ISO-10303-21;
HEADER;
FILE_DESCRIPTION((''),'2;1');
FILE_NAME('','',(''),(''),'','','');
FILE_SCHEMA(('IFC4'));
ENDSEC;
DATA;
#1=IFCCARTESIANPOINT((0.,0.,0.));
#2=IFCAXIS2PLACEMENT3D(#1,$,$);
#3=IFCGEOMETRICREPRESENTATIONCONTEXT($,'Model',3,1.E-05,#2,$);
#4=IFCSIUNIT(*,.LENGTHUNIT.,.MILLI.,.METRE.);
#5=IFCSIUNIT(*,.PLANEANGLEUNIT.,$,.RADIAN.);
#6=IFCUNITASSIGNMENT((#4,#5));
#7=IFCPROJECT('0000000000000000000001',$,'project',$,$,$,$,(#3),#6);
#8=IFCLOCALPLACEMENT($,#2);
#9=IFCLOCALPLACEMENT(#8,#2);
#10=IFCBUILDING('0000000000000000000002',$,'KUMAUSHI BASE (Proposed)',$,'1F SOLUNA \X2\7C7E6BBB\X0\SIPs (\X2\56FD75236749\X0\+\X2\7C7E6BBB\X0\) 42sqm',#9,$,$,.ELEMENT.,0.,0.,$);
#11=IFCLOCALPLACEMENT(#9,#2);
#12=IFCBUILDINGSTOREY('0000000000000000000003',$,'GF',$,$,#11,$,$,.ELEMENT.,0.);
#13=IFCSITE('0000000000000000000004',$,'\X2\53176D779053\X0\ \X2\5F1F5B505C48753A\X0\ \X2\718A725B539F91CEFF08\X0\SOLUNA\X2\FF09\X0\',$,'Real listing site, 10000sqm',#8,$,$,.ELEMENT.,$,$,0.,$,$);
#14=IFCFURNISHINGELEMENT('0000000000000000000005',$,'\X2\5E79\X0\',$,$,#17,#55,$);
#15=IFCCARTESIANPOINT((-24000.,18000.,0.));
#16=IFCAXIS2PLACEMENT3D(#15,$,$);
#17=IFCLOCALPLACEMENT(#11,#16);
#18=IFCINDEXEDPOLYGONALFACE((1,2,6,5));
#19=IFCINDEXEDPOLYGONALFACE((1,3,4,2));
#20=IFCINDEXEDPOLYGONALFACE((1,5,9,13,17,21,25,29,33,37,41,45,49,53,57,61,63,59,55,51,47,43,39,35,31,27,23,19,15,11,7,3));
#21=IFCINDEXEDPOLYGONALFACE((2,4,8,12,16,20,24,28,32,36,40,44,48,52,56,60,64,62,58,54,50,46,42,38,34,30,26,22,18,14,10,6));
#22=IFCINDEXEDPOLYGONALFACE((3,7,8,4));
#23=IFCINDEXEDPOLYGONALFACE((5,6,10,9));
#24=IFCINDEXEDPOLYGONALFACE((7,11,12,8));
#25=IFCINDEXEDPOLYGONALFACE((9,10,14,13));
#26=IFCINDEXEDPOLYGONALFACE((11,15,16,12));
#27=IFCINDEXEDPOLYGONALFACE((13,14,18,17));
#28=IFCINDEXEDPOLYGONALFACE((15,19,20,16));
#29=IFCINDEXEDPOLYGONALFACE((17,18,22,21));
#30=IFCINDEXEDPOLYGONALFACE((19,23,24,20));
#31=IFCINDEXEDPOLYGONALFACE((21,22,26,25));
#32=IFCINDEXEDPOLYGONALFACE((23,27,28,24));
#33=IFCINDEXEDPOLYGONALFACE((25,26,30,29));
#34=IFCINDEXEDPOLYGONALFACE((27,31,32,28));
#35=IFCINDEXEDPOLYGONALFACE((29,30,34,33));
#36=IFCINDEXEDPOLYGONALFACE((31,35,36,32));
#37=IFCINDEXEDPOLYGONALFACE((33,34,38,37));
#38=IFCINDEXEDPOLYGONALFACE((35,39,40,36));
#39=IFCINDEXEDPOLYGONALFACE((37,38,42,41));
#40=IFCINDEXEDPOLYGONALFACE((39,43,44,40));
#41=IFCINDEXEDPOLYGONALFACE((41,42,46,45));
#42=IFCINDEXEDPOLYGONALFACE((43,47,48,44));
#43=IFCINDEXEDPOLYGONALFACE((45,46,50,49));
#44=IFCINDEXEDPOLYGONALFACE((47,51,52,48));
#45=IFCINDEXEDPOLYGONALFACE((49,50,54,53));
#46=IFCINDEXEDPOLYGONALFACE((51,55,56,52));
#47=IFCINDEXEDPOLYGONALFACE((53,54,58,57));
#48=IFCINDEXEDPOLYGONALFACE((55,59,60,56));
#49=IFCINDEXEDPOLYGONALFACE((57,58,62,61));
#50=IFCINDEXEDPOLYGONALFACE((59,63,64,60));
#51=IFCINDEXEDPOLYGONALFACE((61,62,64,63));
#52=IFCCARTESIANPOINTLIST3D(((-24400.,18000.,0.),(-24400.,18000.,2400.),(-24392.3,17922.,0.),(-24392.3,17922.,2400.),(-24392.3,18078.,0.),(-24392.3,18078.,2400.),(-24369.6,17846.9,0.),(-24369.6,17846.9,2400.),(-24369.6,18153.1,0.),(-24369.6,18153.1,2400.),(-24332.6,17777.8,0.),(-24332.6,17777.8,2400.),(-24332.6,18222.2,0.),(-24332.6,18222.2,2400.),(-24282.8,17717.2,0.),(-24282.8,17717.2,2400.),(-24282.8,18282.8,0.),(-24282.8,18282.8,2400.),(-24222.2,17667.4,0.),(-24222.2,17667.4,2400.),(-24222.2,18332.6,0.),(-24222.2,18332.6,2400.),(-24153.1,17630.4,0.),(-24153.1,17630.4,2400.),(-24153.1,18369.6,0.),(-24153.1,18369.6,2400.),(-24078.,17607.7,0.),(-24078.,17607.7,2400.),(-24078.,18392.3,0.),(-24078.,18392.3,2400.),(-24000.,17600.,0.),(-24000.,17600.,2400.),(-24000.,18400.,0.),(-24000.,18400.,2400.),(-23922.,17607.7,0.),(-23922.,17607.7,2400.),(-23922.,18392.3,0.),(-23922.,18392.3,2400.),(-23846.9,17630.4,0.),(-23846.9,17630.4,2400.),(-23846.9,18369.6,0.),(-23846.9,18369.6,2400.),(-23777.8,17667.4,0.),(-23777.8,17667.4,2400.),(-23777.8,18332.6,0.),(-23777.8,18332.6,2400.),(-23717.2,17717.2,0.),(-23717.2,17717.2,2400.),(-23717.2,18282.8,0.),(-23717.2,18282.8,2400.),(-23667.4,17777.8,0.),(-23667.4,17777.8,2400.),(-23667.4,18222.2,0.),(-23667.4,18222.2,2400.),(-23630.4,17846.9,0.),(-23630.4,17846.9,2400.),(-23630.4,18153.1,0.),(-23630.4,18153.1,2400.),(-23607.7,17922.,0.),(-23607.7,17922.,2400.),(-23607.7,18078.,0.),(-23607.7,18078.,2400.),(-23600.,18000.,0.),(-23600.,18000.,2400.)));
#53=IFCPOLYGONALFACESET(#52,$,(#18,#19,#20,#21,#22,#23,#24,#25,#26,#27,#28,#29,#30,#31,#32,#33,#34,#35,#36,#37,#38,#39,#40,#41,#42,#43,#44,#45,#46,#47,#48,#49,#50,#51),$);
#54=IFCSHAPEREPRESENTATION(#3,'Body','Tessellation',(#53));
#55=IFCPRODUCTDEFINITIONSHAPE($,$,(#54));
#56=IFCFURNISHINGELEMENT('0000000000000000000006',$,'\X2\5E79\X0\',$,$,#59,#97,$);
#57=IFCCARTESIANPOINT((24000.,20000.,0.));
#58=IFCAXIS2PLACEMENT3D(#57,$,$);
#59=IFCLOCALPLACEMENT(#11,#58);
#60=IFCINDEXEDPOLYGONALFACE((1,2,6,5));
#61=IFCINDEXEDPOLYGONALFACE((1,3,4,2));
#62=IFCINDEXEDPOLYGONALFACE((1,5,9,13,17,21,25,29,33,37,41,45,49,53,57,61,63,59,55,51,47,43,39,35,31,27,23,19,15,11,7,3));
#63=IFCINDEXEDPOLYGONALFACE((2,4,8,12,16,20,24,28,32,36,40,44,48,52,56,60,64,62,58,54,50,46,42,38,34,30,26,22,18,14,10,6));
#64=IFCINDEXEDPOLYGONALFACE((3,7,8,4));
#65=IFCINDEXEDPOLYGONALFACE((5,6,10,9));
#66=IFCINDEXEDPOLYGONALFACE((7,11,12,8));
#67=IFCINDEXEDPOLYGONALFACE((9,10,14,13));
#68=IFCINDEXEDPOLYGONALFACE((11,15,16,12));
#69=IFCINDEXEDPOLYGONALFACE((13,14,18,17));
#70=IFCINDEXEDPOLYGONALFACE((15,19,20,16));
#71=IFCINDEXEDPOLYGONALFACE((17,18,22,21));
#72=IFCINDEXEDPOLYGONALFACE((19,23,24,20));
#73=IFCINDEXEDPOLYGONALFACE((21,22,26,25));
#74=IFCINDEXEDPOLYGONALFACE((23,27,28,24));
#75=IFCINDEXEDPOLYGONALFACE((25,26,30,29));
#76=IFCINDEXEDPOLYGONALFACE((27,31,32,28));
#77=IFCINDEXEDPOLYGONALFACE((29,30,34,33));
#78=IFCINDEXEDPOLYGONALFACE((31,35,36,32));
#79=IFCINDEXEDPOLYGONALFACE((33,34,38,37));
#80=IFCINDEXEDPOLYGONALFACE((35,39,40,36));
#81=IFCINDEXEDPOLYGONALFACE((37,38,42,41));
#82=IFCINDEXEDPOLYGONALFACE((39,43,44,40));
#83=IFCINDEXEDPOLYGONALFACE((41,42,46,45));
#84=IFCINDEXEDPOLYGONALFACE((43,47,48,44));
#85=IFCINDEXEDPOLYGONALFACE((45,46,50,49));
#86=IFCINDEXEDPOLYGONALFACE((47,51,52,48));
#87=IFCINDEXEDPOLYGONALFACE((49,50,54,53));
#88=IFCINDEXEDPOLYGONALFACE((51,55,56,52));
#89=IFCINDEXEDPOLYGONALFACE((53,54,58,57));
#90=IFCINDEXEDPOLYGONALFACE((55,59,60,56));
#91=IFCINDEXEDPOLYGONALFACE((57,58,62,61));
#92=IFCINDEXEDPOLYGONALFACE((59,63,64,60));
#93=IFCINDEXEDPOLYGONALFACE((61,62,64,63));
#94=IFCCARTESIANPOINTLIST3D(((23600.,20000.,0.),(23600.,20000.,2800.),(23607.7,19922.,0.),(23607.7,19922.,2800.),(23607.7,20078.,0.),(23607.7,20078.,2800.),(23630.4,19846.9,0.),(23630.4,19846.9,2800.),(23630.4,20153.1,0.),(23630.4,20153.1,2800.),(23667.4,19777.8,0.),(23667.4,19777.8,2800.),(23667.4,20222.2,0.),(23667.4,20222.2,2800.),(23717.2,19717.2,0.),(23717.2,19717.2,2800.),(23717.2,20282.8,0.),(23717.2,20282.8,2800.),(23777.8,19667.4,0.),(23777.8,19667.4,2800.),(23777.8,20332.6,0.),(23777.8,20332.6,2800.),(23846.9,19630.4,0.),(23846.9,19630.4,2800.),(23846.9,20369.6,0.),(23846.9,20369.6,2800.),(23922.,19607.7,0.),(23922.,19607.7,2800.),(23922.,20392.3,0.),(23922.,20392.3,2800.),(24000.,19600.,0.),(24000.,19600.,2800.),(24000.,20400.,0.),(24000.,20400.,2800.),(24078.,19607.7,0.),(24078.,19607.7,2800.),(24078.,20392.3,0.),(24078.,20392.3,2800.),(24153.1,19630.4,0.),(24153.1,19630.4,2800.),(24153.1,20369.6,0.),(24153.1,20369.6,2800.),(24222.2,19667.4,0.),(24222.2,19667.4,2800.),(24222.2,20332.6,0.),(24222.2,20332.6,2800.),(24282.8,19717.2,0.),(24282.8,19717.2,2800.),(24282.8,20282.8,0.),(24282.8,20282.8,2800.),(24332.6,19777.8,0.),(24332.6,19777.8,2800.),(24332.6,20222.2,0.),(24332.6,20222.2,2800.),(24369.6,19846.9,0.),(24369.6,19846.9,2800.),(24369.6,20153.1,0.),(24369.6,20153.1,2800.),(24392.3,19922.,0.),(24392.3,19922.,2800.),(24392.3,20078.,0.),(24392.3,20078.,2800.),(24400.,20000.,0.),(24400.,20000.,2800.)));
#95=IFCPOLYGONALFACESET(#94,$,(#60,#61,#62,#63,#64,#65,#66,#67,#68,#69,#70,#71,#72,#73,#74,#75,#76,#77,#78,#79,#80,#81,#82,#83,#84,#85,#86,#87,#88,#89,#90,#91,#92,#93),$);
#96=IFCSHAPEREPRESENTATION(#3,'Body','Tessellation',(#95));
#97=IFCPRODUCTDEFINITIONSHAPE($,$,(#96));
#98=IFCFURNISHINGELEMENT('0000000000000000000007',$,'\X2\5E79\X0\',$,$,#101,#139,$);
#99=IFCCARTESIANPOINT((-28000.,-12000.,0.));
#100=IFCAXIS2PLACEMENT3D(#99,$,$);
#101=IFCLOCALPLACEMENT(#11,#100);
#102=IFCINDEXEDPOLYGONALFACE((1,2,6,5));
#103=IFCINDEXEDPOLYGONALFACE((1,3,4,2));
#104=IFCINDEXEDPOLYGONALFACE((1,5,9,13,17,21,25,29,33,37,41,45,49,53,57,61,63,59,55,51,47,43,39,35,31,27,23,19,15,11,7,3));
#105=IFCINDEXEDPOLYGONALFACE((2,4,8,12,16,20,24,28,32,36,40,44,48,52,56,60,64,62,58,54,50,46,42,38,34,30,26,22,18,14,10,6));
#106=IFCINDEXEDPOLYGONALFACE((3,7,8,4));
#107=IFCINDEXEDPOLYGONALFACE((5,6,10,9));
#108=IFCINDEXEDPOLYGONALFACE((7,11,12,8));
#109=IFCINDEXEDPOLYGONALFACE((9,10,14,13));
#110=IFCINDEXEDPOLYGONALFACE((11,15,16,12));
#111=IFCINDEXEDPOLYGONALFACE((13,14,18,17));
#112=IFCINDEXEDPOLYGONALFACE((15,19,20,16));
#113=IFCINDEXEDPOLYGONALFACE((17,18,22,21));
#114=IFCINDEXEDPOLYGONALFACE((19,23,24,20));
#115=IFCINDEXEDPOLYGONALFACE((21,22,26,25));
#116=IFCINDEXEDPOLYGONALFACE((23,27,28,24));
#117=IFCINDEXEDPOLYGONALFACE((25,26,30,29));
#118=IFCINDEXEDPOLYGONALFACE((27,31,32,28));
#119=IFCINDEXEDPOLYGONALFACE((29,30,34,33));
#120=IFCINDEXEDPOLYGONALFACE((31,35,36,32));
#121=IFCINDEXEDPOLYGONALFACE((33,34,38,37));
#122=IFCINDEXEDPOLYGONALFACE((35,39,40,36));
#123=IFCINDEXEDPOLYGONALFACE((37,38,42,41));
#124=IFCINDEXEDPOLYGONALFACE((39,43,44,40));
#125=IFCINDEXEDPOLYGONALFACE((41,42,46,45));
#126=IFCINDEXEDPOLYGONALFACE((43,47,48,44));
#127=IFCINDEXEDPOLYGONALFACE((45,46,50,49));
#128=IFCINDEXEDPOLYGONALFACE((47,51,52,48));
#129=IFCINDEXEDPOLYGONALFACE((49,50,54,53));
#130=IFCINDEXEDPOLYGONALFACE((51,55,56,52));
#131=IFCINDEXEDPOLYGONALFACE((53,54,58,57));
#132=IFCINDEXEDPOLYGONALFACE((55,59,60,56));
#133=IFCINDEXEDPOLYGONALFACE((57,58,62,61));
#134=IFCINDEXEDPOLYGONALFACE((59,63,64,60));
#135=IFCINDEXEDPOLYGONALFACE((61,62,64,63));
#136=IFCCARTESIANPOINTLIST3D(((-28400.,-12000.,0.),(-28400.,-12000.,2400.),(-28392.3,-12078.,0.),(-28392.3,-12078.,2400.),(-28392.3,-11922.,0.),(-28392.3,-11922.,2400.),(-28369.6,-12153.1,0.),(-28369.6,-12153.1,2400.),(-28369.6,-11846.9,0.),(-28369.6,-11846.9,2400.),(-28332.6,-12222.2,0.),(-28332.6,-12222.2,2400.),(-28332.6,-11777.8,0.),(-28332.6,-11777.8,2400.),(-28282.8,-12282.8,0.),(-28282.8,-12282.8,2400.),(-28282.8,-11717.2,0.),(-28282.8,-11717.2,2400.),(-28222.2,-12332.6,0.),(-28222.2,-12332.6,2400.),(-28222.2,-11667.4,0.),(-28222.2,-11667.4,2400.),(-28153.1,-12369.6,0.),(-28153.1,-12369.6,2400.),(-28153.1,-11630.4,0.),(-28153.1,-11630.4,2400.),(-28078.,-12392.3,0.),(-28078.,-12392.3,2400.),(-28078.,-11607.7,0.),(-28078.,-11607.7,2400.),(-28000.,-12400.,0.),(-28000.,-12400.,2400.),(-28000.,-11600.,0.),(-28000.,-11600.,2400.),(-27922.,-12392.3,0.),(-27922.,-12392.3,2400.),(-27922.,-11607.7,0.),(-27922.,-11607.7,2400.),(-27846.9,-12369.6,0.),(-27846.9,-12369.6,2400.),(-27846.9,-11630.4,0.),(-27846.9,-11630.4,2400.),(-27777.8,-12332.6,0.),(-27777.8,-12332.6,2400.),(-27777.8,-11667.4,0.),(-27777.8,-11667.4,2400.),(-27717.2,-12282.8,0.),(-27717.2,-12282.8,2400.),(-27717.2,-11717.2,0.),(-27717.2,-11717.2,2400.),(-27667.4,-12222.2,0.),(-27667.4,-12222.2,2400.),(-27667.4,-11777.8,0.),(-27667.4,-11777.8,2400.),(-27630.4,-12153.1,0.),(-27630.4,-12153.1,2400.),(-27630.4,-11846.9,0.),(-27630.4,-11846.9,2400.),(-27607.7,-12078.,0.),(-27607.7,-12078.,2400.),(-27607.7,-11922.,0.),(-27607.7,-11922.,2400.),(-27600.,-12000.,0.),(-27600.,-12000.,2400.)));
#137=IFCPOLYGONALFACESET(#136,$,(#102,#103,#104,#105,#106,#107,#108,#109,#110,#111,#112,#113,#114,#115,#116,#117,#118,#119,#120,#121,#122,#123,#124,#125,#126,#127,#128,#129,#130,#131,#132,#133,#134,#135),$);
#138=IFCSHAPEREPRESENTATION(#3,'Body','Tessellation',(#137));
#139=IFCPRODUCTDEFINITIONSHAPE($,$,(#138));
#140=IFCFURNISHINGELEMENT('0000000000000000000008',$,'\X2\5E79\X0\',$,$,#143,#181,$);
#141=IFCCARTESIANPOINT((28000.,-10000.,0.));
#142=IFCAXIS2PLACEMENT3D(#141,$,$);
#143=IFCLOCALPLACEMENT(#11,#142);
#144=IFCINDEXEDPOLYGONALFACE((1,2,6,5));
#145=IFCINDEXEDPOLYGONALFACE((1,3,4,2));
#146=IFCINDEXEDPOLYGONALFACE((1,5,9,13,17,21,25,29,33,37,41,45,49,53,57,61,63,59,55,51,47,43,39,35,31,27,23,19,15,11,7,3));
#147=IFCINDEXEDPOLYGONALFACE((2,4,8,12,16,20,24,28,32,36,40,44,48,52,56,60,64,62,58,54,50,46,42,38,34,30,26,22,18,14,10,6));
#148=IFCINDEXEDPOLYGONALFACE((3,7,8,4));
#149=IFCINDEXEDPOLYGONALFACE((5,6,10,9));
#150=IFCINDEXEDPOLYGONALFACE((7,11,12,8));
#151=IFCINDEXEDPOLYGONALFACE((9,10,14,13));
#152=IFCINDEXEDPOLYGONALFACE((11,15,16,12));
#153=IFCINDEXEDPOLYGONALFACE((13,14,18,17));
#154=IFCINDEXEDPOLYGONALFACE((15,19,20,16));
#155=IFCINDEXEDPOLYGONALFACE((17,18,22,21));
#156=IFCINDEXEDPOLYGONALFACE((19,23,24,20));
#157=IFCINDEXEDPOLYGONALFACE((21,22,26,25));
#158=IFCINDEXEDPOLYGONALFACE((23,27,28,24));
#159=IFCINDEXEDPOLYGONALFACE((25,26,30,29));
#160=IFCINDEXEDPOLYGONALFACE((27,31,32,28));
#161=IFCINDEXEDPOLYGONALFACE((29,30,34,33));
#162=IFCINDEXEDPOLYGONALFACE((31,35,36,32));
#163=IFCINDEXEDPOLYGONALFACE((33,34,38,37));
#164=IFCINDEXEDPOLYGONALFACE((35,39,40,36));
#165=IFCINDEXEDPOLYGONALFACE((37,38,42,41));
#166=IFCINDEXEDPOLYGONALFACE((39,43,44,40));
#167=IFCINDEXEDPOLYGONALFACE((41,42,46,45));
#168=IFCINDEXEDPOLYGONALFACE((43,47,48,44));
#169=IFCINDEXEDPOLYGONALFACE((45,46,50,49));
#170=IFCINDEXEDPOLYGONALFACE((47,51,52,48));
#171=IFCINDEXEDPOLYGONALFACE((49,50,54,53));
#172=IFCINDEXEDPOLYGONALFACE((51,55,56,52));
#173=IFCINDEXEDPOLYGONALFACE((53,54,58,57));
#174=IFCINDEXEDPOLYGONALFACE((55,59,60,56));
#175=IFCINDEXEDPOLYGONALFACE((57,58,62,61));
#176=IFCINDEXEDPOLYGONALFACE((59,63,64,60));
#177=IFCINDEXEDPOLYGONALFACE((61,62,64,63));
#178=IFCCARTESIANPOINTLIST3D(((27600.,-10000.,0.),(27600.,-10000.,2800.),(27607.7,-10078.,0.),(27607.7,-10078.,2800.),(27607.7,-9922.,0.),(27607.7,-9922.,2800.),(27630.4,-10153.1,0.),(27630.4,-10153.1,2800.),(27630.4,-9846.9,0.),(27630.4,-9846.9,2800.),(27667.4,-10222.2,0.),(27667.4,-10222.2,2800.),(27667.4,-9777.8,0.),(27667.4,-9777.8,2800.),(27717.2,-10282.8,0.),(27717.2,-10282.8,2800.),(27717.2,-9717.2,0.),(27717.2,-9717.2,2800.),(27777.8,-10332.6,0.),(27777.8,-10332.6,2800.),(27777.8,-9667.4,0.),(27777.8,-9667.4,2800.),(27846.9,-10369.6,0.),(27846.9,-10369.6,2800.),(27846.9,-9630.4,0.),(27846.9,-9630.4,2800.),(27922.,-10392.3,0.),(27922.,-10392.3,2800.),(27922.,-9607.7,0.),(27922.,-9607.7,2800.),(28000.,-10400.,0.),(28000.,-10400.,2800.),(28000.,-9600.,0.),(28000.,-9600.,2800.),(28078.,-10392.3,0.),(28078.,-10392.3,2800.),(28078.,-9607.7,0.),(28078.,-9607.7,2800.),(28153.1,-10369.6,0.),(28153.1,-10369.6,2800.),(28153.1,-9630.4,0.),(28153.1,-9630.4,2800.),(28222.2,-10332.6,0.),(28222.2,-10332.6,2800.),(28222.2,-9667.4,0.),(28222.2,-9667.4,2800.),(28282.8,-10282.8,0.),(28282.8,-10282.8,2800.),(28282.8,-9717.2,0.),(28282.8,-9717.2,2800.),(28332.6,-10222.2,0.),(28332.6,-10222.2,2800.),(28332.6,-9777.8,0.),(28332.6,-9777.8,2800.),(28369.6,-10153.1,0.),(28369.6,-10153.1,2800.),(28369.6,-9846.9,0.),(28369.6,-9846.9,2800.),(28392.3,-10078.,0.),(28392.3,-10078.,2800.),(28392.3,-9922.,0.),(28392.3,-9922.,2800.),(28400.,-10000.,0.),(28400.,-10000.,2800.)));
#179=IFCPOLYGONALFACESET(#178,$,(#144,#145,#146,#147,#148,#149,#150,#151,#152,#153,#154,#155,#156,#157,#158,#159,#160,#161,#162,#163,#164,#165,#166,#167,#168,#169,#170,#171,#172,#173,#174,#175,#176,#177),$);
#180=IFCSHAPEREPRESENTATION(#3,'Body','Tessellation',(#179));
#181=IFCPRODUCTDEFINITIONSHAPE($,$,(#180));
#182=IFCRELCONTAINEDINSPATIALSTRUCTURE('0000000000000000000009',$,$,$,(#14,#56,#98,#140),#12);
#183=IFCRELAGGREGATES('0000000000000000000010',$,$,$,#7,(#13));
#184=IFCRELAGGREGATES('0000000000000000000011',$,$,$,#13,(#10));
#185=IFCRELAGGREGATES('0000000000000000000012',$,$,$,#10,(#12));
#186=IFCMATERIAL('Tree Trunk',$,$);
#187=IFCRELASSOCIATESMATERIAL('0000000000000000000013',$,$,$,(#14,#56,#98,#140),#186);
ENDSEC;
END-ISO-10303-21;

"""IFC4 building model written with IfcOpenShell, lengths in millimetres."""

from ifc_helpers import new_model, si_unit, frame, origin, origin_2d, place, context, project, spatial, circle, extrude, material, element, save


model = new_model("IFC4")

# Units and contexts
model_context = context("Model", 3, precision=1e-05, world=origin())
ifc_project = project(units=[si_unit("LENGTHUNIT", "METRE", prefix="MILLI"), si_unit("PLANEANGLEUNIT", "RADIAN")], contexts=[model_context])

# Site, building, storey
site_placement = place(None, origin())
site = spatial("IfcSite", under=ifc_project, at=site_placement, Name="北海道 弟子屈町 熊牛原野（SOLUNA）", ObjectType="Real listing site, 10000sqm", CompositionType="ELEMENT", RefElevation=0.0)
building_placement = place(site_placement, origin())
building = spatial("IfcBuilding", under=site, at=building_placement, Name="KUMAUSHI BASE (Proposed)", ObjectType="1F SOLUNA 籾殻SIPs (国産杉+籾殻) 42sqm", CompositionType="ELEMENT", ElevationOfRefHeight=0.0, ElevationOfTerrain=0.0)
storey_placement = place(building_placement, origin())
storey = spatial("IfcBuildingStorey", under=building, at=storey_placement, Name="GF", CompositionType="ELEMENT", Elevation=0.0)

# Furnishing elements
ifc_material_1 = material(Name="Tree Trunk")
furnishing_1_placement = place(storey_placement, frame((-24000.0, 18000.0, 0.0)))
element("IfcFurnishingElement", 1, at=furnishing_1_placement, inside=storey, material=ifc_material_1, Name="幹", context=model_context, shape_type="SweptSolid", body=[
    extrude(circle(Radius=400.0, at=origin_2d()), frame((-24000.0, 18000.0, 0.0)), (0.0, 0.0, 1.0), 2400.0),
])
furnishing_2_placement = place(storey_placement, frame((24000.0, 20000.0, 0.0)))
element("IfcFurnishingElement", 2, at=furnishing_2_placement, inside=storey, material=ifc_material_1, Name="幹", context=model_context, shape_type="SweptSolid", body=[
    extrude(circle(Radius=400.0, at=origin_2d()), frame((24000.0, 20000.0, 0.0)), (0.0, 0.0, 1.0), 2800.0),
])
furnishing_3_placement = place(storey_placement, frame((-28000.0, -12000.0, 0.0)))
element("IfcFurnishingElement", 3, at=furnishing_3_placement, inside=storey, material=ifc_material_1, Name="幹", context=model_context, shape_type="SweptSolid", body=[
    extrude(circle(Radius=400.0, at=origin_2d()), frame((-28000.0, -12000.0, 0.0)), (0.0, 0.0, 1.0), 2400.0),
])
furnishing_4_placement = place(storey_placement, frame((28000.0, -10000.0, 0.0)))
element("IfcFurnishingElement", 4, at=furnishing_4_placement, inside=storey, material=ifc_material_1, Name="幹", context=model_context, shape_type="SweptSolid", body=[
    extrude(circle(Radius=400.0, at=origin_2d()), frame((28000.0, -10000.0, 0.0)), (0.0, 0.0, 1.0), 2800.0),
])

save(model, "model.ifc")
